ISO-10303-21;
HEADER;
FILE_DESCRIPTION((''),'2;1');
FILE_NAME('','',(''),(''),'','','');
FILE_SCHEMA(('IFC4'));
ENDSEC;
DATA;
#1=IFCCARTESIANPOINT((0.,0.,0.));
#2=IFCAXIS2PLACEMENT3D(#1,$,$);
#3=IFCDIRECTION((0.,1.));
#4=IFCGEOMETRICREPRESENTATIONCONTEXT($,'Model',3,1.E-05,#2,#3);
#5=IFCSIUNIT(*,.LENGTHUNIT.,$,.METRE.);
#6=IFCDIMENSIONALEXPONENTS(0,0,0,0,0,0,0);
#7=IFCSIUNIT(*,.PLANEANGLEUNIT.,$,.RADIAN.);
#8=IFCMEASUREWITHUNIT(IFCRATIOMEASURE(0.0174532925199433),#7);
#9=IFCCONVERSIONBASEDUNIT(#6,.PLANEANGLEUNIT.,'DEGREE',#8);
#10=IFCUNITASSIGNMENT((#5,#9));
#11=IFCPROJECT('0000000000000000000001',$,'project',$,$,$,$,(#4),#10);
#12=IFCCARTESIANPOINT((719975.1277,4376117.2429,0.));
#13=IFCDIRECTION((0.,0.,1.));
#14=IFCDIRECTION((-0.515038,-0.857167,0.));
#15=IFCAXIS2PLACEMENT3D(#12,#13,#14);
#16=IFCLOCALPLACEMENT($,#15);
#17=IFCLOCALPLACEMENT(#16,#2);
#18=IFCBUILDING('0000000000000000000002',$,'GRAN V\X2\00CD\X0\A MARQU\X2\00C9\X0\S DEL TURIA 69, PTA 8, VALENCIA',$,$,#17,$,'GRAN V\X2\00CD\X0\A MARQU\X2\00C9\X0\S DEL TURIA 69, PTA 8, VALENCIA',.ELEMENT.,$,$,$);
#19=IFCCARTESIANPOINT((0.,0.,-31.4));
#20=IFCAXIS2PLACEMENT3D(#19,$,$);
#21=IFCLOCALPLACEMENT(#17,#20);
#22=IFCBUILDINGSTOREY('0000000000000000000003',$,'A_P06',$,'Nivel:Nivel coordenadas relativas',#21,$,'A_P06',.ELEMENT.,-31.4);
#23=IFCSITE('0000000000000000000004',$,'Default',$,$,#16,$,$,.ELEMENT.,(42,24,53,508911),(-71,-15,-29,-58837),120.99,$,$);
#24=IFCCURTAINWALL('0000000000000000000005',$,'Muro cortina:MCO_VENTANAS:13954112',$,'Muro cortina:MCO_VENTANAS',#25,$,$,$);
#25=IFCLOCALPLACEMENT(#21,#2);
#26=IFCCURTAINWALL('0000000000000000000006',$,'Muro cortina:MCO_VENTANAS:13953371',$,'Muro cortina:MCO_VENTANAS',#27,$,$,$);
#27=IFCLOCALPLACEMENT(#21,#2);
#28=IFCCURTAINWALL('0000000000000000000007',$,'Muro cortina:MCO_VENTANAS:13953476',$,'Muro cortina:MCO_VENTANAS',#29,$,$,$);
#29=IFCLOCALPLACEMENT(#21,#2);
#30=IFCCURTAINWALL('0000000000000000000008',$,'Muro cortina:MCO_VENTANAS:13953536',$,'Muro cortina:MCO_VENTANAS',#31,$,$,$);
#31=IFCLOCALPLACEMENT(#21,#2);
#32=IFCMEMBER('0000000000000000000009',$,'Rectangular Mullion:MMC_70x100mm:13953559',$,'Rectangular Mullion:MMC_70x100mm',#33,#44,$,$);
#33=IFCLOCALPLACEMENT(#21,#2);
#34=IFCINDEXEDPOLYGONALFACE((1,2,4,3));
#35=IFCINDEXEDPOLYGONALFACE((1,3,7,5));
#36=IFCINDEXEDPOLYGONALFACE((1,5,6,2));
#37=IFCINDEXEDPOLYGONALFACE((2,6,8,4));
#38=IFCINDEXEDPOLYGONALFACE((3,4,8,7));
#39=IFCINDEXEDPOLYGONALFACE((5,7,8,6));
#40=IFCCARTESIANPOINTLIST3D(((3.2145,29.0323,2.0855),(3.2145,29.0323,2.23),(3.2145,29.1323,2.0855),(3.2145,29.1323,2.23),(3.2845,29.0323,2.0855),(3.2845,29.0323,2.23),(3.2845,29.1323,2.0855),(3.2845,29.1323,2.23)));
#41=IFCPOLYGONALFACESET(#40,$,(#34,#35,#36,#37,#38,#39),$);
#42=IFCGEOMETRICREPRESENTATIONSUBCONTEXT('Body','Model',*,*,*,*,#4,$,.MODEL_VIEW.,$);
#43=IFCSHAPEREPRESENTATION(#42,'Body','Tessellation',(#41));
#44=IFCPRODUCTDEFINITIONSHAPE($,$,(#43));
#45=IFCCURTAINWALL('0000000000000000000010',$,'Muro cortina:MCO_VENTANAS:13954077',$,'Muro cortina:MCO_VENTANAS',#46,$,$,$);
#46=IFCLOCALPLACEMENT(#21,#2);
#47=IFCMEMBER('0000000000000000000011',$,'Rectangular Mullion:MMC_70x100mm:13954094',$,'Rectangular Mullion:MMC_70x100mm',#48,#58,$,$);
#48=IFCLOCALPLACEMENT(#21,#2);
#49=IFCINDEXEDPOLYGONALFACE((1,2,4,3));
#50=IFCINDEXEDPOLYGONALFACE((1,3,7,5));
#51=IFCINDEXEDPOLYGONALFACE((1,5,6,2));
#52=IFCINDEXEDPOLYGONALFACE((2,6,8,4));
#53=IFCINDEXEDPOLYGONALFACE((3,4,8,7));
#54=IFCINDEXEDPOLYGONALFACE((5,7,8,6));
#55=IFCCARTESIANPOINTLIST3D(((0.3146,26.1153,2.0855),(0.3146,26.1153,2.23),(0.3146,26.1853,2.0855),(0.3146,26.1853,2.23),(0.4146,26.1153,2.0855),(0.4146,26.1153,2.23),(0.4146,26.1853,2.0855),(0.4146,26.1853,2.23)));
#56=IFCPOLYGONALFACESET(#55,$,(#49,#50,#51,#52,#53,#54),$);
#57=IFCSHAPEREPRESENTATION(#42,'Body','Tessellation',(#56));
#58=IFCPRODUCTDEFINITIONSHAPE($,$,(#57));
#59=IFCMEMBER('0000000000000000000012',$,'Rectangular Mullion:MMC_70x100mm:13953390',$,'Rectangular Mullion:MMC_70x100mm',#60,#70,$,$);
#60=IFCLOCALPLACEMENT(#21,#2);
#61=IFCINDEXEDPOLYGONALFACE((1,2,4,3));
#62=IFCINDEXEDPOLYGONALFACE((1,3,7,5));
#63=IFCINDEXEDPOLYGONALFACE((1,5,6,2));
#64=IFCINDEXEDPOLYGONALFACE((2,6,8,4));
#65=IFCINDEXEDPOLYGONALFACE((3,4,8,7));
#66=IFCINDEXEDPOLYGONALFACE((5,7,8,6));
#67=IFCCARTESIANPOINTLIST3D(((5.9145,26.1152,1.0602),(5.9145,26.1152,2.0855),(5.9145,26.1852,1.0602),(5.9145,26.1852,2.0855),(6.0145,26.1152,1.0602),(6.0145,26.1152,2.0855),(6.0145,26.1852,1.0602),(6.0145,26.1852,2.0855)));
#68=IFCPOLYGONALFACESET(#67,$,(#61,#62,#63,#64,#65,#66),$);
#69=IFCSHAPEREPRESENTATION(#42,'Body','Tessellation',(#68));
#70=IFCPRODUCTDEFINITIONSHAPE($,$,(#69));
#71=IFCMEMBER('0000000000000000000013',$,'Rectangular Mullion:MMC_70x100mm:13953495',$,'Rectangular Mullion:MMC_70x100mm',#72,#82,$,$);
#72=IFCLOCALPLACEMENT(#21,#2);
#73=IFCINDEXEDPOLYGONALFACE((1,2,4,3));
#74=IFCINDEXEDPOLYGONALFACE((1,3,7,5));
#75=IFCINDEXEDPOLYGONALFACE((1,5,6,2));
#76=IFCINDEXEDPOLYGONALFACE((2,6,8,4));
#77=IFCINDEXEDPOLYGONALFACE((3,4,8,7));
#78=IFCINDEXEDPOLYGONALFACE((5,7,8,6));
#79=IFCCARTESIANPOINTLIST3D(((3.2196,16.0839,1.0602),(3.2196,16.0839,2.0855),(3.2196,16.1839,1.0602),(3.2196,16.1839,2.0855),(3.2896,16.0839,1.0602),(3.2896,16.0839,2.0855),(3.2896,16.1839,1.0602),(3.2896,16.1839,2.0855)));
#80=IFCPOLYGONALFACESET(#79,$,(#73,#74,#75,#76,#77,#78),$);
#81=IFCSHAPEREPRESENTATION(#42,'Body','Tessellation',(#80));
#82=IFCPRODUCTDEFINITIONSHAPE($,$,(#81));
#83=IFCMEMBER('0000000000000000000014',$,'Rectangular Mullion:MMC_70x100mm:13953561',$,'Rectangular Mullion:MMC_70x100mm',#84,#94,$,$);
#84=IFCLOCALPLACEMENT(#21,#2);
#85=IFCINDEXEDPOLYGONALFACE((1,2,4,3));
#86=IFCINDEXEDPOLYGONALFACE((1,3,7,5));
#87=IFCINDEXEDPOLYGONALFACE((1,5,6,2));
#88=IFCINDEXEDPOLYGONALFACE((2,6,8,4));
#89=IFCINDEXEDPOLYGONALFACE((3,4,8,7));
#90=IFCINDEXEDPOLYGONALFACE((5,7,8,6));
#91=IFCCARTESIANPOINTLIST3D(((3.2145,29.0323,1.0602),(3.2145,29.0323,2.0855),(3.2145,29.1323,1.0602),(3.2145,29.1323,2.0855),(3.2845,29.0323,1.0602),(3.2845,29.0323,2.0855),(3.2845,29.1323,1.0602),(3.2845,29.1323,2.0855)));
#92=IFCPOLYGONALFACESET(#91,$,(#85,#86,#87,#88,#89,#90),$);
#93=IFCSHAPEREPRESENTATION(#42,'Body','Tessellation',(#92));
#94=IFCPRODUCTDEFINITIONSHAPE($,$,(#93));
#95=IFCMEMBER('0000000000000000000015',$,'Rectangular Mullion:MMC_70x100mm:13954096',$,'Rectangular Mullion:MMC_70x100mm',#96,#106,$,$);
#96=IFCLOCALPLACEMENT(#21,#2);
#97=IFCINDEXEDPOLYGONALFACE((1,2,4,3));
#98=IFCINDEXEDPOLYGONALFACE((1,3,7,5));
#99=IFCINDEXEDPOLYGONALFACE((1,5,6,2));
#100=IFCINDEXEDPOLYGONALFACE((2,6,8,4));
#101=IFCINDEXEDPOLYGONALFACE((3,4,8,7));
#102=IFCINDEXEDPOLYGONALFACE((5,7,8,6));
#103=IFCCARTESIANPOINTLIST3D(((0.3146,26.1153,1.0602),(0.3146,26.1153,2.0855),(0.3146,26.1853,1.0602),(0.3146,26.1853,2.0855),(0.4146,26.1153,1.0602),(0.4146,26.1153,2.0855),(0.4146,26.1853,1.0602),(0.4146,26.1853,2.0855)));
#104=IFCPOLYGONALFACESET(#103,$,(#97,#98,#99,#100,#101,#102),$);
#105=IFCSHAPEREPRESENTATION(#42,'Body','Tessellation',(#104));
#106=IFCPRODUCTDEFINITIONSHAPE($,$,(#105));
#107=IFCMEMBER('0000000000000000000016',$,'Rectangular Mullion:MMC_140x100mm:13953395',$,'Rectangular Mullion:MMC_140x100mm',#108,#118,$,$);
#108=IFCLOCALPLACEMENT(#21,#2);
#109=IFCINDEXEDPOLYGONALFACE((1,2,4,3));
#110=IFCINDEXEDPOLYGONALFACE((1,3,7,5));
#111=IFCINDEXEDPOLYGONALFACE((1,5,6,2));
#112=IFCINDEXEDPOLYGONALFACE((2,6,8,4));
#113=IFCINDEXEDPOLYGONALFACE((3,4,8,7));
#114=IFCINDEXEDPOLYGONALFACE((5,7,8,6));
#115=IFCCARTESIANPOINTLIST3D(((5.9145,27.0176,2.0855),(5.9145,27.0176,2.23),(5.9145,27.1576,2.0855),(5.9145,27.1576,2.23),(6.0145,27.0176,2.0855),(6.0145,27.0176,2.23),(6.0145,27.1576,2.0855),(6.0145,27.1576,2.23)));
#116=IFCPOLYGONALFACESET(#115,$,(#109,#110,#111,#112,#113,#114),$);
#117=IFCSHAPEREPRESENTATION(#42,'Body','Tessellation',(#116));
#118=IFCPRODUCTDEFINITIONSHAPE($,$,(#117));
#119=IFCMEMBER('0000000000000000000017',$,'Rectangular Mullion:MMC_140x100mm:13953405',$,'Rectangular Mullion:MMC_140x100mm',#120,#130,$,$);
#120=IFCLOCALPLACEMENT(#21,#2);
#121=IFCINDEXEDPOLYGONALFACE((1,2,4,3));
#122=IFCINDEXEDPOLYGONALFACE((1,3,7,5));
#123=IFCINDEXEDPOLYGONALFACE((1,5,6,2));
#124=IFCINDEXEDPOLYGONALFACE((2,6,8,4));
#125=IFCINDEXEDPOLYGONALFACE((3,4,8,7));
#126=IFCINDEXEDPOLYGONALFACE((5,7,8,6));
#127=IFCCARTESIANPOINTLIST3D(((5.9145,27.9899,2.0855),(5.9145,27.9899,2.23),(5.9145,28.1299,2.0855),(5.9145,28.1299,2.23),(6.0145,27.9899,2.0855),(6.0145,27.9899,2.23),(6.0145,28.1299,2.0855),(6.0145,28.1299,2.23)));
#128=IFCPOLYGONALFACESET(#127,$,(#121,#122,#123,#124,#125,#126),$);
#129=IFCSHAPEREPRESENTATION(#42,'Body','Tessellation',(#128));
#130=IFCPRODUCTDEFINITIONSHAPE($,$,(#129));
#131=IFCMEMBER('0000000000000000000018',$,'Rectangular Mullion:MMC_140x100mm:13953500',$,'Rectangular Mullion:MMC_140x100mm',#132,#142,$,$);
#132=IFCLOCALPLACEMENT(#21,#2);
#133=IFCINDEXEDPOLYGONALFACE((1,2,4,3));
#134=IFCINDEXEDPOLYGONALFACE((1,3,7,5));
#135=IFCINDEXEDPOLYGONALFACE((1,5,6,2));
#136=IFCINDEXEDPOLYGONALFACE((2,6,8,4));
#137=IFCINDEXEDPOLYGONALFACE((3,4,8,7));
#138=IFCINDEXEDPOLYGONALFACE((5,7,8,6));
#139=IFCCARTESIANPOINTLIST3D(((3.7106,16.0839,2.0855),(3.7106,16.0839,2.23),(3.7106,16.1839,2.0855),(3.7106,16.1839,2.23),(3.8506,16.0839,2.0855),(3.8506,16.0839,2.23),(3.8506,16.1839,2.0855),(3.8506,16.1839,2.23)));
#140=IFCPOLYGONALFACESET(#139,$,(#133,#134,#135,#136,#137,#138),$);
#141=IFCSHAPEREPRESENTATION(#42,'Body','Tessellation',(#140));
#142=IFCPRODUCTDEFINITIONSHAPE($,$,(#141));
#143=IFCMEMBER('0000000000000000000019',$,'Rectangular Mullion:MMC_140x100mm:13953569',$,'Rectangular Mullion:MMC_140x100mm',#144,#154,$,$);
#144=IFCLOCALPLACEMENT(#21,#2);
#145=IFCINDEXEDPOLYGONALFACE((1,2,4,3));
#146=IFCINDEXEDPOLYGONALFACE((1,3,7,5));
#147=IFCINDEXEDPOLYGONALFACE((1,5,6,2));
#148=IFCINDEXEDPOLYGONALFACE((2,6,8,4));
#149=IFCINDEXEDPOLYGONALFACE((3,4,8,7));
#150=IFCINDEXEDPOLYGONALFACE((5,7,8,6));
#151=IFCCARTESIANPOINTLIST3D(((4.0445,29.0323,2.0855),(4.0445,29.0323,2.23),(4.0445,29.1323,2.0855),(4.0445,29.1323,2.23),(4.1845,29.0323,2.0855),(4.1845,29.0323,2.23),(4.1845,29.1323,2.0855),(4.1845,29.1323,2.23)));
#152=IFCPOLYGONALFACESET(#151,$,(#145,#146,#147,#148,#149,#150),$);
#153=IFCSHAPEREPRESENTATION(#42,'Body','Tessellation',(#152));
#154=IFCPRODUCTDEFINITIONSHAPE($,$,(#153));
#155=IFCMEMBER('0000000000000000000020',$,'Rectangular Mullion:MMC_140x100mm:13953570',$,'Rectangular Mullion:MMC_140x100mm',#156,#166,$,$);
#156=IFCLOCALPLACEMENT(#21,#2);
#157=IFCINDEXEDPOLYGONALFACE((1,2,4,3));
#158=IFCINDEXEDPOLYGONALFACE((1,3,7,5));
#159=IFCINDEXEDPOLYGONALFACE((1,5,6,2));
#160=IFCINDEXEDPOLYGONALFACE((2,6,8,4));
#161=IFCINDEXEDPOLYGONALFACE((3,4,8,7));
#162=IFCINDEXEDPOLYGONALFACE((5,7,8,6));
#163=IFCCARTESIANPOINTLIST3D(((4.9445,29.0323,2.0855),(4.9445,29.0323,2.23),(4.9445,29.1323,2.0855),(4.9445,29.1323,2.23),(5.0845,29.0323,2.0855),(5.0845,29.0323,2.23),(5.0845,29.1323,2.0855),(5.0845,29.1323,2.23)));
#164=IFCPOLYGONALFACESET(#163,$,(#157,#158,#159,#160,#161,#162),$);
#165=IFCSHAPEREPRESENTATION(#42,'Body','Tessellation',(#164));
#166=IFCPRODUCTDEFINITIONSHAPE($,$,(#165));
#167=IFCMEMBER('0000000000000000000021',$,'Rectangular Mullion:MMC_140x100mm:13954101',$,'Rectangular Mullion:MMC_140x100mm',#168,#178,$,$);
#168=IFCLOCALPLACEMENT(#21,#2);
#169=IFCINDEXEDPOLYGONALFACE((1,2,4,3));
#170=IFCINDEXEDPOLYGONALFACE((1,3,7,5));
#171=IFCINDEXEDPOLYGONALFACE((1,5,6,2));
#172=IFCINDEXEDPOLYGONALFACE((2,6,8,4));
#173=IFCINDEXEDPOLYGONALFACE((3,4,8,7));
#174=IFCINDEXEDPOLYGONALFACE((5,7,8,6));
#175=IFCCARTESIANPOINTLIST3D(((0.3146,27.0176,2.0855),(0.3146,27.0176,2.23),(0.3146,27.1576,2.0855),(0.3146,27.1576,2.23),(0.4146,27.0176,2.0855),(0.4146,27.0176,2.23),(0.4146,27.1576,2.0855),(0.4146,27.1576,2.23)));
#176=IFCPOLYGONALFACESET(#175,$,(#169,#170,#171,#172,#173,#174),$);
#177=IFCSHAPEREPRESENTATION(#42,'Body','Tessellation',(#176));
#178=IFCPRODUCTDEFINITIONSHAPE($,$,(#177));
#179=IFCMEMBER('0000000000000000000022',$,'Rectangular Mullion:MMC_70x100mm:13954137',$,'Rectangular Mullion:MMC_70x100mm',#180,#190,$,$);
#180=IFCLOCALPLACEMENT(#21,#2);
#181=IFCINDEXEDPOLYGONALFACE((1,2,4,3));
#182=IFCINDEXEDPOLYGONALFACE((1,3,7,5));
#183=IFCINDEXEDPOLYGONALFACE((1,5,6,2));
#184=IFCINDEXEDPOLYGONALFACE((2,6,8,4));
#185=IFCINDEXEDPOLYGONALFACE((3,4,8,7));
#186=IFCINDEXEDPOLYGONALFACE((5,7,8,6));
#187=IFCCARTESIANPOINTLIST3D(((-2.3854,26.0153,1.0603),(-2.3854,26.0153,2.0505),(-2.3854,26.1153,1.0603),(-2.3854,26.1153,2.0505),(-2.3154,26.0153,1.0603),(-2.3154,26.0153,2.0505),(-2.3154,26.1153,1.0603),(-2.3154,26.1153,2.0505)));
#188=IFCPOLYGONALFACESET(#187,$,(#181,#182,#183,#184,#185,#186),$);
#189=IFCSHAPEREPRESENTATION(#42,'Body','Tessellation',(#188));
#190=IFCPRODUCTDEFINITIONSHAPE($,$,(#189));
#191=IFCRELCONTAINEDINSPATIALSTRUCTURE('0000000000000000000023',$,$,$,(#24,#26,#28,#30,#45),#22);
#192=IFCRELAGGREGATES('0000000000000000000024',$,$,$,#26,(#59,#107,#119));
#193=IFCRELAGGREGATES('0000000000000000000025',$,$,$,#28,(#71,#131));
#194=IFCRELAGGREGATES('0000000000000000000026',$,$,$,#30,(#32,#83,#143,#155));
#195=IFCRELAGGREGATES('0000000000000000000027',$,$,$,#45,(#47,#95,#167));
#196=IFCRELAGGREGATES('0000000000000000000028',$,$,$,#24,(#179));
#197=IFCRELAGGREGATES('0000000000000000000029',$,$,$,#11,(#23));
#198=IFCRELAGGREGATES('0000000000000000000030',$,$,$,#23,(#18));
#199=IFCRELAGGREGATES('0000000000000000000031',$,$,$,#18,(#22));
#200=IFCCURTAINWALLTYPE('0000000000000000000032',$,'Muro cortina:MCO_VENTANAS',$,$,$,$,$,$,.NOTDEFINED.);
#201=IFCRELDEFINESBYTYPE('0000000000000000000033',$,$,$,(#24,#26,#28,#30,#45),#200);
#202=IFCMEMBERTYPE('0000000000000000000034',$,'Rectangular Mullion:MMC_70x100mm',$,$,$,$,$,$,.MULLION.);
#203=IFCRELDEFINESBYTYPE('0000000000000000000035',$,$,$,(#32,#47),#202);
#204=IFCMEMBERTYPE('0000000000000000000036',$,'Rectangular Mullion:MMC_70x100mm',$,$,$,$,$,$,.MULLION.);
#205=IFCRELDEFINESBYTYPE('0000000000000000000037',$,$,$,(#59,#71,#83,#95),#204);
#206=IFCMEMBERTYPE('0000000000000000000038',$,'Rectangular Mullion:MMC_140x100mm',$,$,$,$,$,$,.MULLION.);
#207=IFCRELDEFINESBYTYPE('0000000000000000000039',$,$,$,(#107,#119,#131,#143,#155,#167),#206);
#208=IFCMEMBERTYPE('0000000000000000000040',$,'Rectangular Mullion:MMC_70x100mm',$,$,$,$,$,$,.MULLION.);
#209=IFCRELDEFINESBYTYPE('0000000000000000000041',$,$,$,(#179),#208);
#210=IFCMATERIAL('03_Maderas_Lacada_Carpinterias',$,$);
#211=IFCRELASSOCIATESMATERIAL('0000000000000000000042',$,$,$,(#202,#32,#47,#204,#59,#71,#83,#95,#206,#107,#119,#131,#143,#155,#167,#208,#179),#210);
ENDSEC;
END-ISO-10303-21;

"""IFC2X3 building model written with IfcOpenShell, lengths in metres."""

from ifc_helpers import new_model, entity, si_unit, converted_unit, direction, frame, origin, origin_2d_with_axis, place, context, subcontext, project, spatial, rectangle, extrude, source, transform, mapped, material, type_object, type_shapes, element, aggregate, save


model = new_model("IFC2X3")

# Units and contexts
model_context = context("Model", 3, precision=1e-05, world=origin(), true_north=direction((0.0, 1.0)))
body_context = subcontext(model_context, "Body", "Model", "MODEL_VIEW")
ifc_project = project(units=[si_unit("LENGTHUNIT", "METRE"), converted_unit("PLANEANGLEUNIT", "DEGREE", entity("IfcRatioMeasure", 0.0174532925199433), si_unit("PLANEANGLEUNIT", "RADIAN"), dimensions=[0, 0, 0, 0, 0, 0, 0])], contexts=[model_context])

# Site, building, storey
site_placement = place(None, frame((719975.1277, 4376117.2429, 0.0), z_axis=(0.0, 0.0, 1.0), x_axis=(-0.515038, -0.857167, 0.0)))
site = spatial("IfcSite", under=ifc_project, at=site_placement, Name="Default", CompositionType="ELEMENT", RefLatitude=(42, 24, 53, 508911), RefLongitude=(-71, -15, -29, -58837), RefElevation=120.99)
building_placement = place(site_placement, origin())
building = spatial("IfcBuilding", under=site, at=building_placement, Name="GRAN VÍA MARQUÉS DEL TURIA 69, PTA 8, VALENCIA", LongName="GRAN VÍA MARQUÉS DEL TURIA 69, PTA 8, VALENCIA", CompositionType="ELEMENT")
storey_placement = place(building_placement, frame((0.0, 0.0, -31.4)))
storey = spatial("IfcBuildingStorey", under=building, at=storey_placement, Name="A_P06", ObjectType="Nivel:Nivel coordenadas relativas", LongName="A_P06", CompositionType="ELEMENT", Elevation=-31.4)

# Curtain wall
curtain_wall_type = type_object("IfcCurtainWallType", Name="Muro cortina:MCO_VENTANAS", PredefinedType="NOTDEFINED")
ifc_material_1 = material(Name="03_Maderas_Lacada_Carpinterias")
curtain_wall_1_placement = place(storey_placement, frame((0.0, 0.0, 31.4)))
curtain_wall_1 = element("IfcCurtainWall", 1, at=curtain_wall_1_placement, inside=storey, type_object=curtain_wall_type, Name="Muro cortina:MCO_VENTANAS:13954112", ObjectType="Muro cortina:MCO_VENTANAS")

# Curtain walls
curtain_wall_2_placement = place(storey_placement, frame((0.0, 0.0, 31.4)))
curtain_wall_2 = element("IfcCurtainWall", 2, at=curtain_wall_2_placement, inside=storey, type_object=curtain_wall_type, Name="Muro cortina:MCO_VENTANAS:13953371", ObjectType="Muro cortina:MCO_VENTANAS")
curtain_wall_3_placement = place(storey_placement, frame((0.0, 0.0, 31.4)))
curtain_wall_3 = element("IfcCurtainWall", 3, at=curtain_wall_3_placement, inside=storey, type_object=curtain_wall_type, Name="Muro cortina:MCO_VENTANAS:13953476", ObjectType="Muro cortina:MCO_VENTANAS")
curtain_wall_4_placement = place(storey_placement, frame((0.0, 0.0, 31.4)))
curtain_wall_4 = element("IfcCurtainWall", 4, at=curtain_wall_4_placement, inside=storey, type_object=curtain_wall_type, Name="Muro cortina:MCO_VENTANAS:13953536", ObjectType="Muro cortina:MCO_VENTANAS")

# Member
member_type_1 = type_object("IfcMemberType", Name="Rectangular Mullion:MMC_70x100mm", PredefinedType="MULLION", material=ifc_material_1)
shared_shape_1 = source(origin(), body_context, "Body", "SweptSolid", [
    extrude(rectangle(XDim=0.1, YDim=0.07, at=origin_2d_with_axis()), frame((-0.035, 0.0, -0.1445), z_axis=(0.0, 0.0, 1.0), x_axis=(0.0, -1.0, 0.0)), (0.0, 0.0, 1.0), 0.1445),
])
type_shapes(member_type_1, [shared_shape_1])
member_1_placement = place(storey_placement, frame((3.2145, 29.0823, 2.23), z_axis=(0.0, 0.0, 1.0), x_axis=(-1.0, -0.00001, 0.0)))
member_1 = element("IfcMember", 5, at=member_1_placement, type_object=member_type_1, material=ifc_material_1, Name="Rectangular Mullion:MMC_70x100mm:13953559", ObjectType="Rectangular Mullion:MMC_70x100mm", context=body_context, shape_type="MappedRepresentation", body=[
    mapped(shared_shape_1, transform((0.0, 0.0, 0.0), scale=1.0)),
])

# Curtain wall, member
curtain_wall_5_placement = place(storey_placement, frame((0.0, 0.0, 31.4)))
curtain_wall_5 = element("IfcCurtainWall", 6, at=curtain_wall_5_placement, inside=storey, type_object=curtain_wall_type, Name="Muro cortina:MCO_VENTANAS:13954077", ObjectType="Muro cortina:MCO_VENTANAS")
member_2_placement = place(storey_placement, frame((0.3646, 26.1153, 2.23), z_axis=(0.0, 0.0, 1.0), x_axis=(0.0, -1.0, 0.0)))
member_2 = element("IfcMember", 7, at=member_2_placement, type_object=member_type_1, material=ifc_material_1, Name="Rectangular Mullion:MMC_70x100mm:13954094", ObjectType="Rectangular Mullion:MMC_70x100mm", context=body_context, shape_type="MappedRepresentation", body=[
    mapped(shared_shape_1, transform((0.0, 0.0, 0.0), scale=1.0)),
])

# Members
member_type_2 = type_object("IfcMemberType", Name="Rectangular Mullion:MMC_70x100mm", PredefinedType="MULLION", material=ifc_material_1)
shared_shape_2 = source(origin(), body_context, "Body", "SweptSolid", [
    extrude(rectangle(XDim=0.1, YDim=0.07, at=origin_2d_with_axis()), frame((-0.035, 0.0, -1.0252), z_axis=(0.0, 0.0, 1.0), x_axis=(0.0, -1.0, 0.0)), (0.0, 0.0, 1.0), 1.0252),
])
type_shapes(member_type_2, [shared_shape_2])
member_3_placement = place(storey_placement, frame((5.9645, 26.1152, 2.0855), z_axis=(0.0, 0.0, 1.0), x_axis=(0.00001, -1.0, 0.0)))
member_3 = element("IfcMember", 8, at=member_3_placement, type_object=member_type_2, material=ifc_material_1, Name="Rectangular Mullion:MMC_70x100mm:13953390", ObjectType="Rectangular Mullion:MMC_70x100mm", context=body_context, shape_type="MappedRepresentation", body=[
    mapped(shared_shape_2, transform((0.0, 0.0, 0.0), scale=1.0)),
])
member_4_placement = place(storey_placement, frame((3.2196, 16.1339, 2.0855), z_axis=(0.0, 0.0, 1.0), x_axis=(-1.0, -0.00001, 0.0)))
member_4 = element("IfcMember", 9, at=member_4_placement, type_object=member_type_2, material=ifc_material_1, Name="Rectangular Mullion:MMC_70x100mm:13953495", ObjectType="Rectangular Mullion:MMC_70x100mm", context=body_context, shape_type="MappedRepresentation", body=[
    mapped(shared_shape_2, transform((0.0, 0.0, 0.0), scale=1.0)),
])
member_5_placement = place(storey_placement, frame((3.2145, 29.0823, 2.0855), z_axis=(0.0, 0.0, 1.0), x_axis=(-1.0, -0.00001, 0.0)))
member_5 = element("IfcMember", 10, at=member_5_placement, type_object=member_type_2, material=ifc_material_1, Name="Rectangular Mullion:MMC_70x100mm:13953561", ObjectType="Rectangular Mullion:MMC_70x100mm", context=body_context, shape_type="MappedRepresentation", body=[
    mapped(shared_shape_2, transform((0.0, 0.0, 0.0), scale=1.0)),
])
member_6_placement = place(storey_placement, frame((0.3646, 26.1153, 2.0855), z_axis=(0.0, 0.0, 1.0), x_axis=(0.0, -1.0, 0.0)))
member_6 = element("IfcMember", 11, at=member_6_placement, type_object=member_type_2, material=ifc_material_1, Name="Rectangular Mullion:MMC_70x100mm:13954096", ObjectType="Rectangular Mullion:MMC_70x100mm", context=body_context, shape_type="MappedRepresentation", body=[
    mapped(shared_shape_2, transform((0.0, 0.0, 0.0), scale=1.0)),
])
member_type_3 = type_object("IfcMemberType", Name="Rectangular Mullion:MMC_140x100mm", PredefinedType="MULLION", material=ifc_material_1)
shared_shape_3 = source(origin(), body_context, "Body", "SweptSolid", [
    extrude(rectangle(XDim=0.1, YDim=0.14, at=origin_2d_with_axis()), frame((0.0, 0.0, -0.1445), z_axis=(0.0, 0.0, 1.0), x_axis=(0.0, -1.0, 0.0)), (0.0, 0.0, 1.0), 0.1445),
])
type_shapes(member_type_3, [shared_shape_3])
member_7_placement = place(storey_placement, frame((5.9645, 27.0876, 2.0855), z_axis=(0.0, 0.0, -1.0), x_axis=(-0.00001, 1.0, 0.0)))
member_7 = element("IfcMember", 12, at=member_7_placement, type_object=member_type_3, material=ifc_material_1, Name="Rectangular Mullion:MMC_140x100mm:13953395", ObjectType="Rectangular Mullion:MMC_140x100mm", context=body_context, shape_type="MappedRepresentation", body=[
    mapped(shared_shape_3, transform((0.0, 0.0, 0.0), scale=1.0)),
])
member_8_placement = place(storey_placement, frame((5.9645, 28.0599, 2.0855), z_axis=(0.0, 0.0, -1.0), x_axis=(-0.00001, 1.0, 0.0)))
member_8 = element("IfcMember", 13, at=member_8_placement, type_object=member_type_3, material=ifc_material_1, Name="Rectangular Mullion:MMC_140x100mm:13953405", ObjectType="Rectangular Mullion:MMC_140x100mm", context=body_context, shape_type="MappedRepresentation", body=[
    mapped(shared_shape_3, transform((0.0, 0.0, 0.0), scale=1.0)),
])
aggregate(curtain_wall_2, [member_3, member_7, member_8])
member_9_placement = place(storey_placement, frame((3.7806, 16.1339, 2.0855), z_axis=(0.0, 0.0, -1.0), x_axis=(1.0, 0.00001, 0.0)))
member_9 = element("IfcMember", 14, at=member_9_placement, type_object=member_type_3, material=ifc_material_1, Name="Rectangular Mullion:MMC_140x100mm:13953500", ObjectType="Rectangular Mullion:MMC_140x100mm", context=body_context, shape_type="MappedRepresentation", body=[
    mapped(shared_shape_3, transform((0.0, 0.0, 0.0), scale=1.0)),
])
aggregate(curtain_wall_3, [member_4, member_9])
member_10_placement = place(storey_placement, frame((4.1145, 29.0823, 2.0855), z_axis=(0.0, 0.0, -1.0), x_axis=(1.0, 0.00001, 0.0)))
member_10 = element("IfcMember", 15, at=member_10_placement, type_object=member_type_3, material=ifc_material_1, Name="Rectangular Mullion:MMC_140x100mm:13953569", ObjectType="Rectangular Mullion:MMC_140x100mm", context=body_context, shape_type="MappedRepresentation", body=[
    mapped(shared_shape_3, transform((0.0, 0.0, 0.0), scale=1.0)),
])
member_11_placement = place(storey_placement, frame((5.0145, 29.0823, 2.0855), z_axis=(0.0, 0.0, -1.0), x_axis=(1.0, 0.00001, 0.0)))
member_11 = element("IfcMember", 16, at=member_11_placement, type_object=member_type_3, material=ifc_material_1, Name="Rectangular Mullion:MMC_140x100mm:13953570", ObjectType="Rectangular Mullion:MMC_140x100mm", context=body_context, shape_type="MappedRepresentation", body=[
    mapped(shared_shape_3, transform((0.0, 0.0, 0.0), scale=1.0)),
])
aggregate(curtain_wall_4, [member_1, member_5, member_10, member_11])
member_12_placement = place(storey_placement, frame((0.3646, 27.0876, 2.0855), z_axis=(0.0, 0.0, -1.0), x_axis=(0.0, 1.0, 0.0)))
member_12 = element("IfcMember", 17, at=member_12_placement, type_object=member_type_3, material=ifc_material_1, Name="Rectangular Mullion:MMC_140x100mm:13954101", ObjectType="Rectangular Mullion:MMC_140x100mm", context=body_context, shape_type="MappedRepresentation", body=[
    mapped(shared_shape_3, transform((0.0, 0.0, 0.0), scale=1.0)),
])
aggregate(curtain_wall_5, [member_2, member_6, member_12])
member_type_4 = type_object("IfcMemberType", Name="Rectangular Mullion:MMC_70x100mm", PredefinedType="MULLION", material=ifc_material_1)
shared_shape_4 = source(origin(), body_context, "Body", "SweptSolid", [
    extrude(rectangle(XDim=0.1, YDim=0.07, at=origin_2d_with_axis()), frame((-0.035, 0.0, -0.9902), z_axis=(0.0, 0.0, 1.0), x_axis=(0.0, -1.0, 0.0)), (0.0, 0.0, 1.0), 0.9902),
])
type_shapes(member_type_4, [shared_shape_4])
member_13_placement = place(storey_placement, frame((-2.3854, 26.0653, 2.0505), z_axis=(0.0, 0.0, 1.0), x_axis=(-1.0, 0.0, 0.0)))
member_13 = element("IfcMember", 18, at=member_13_placement, type_object=member_type_4, material=ifc_material_1, Name="Rectangular Mullion:MMC_70x100mm:13954137", ObjectType="Rectangular Mullion:MMC_70x100mm", context=body_context, shape_type="MappedRepresentation", body=[
    mapped(shared_shape_4, transform((0.0, 0.0, 0.0), scale=1.0)),
])
aggregate(curtain_wall_1, [member_13])

save(model, "model.ifc")
